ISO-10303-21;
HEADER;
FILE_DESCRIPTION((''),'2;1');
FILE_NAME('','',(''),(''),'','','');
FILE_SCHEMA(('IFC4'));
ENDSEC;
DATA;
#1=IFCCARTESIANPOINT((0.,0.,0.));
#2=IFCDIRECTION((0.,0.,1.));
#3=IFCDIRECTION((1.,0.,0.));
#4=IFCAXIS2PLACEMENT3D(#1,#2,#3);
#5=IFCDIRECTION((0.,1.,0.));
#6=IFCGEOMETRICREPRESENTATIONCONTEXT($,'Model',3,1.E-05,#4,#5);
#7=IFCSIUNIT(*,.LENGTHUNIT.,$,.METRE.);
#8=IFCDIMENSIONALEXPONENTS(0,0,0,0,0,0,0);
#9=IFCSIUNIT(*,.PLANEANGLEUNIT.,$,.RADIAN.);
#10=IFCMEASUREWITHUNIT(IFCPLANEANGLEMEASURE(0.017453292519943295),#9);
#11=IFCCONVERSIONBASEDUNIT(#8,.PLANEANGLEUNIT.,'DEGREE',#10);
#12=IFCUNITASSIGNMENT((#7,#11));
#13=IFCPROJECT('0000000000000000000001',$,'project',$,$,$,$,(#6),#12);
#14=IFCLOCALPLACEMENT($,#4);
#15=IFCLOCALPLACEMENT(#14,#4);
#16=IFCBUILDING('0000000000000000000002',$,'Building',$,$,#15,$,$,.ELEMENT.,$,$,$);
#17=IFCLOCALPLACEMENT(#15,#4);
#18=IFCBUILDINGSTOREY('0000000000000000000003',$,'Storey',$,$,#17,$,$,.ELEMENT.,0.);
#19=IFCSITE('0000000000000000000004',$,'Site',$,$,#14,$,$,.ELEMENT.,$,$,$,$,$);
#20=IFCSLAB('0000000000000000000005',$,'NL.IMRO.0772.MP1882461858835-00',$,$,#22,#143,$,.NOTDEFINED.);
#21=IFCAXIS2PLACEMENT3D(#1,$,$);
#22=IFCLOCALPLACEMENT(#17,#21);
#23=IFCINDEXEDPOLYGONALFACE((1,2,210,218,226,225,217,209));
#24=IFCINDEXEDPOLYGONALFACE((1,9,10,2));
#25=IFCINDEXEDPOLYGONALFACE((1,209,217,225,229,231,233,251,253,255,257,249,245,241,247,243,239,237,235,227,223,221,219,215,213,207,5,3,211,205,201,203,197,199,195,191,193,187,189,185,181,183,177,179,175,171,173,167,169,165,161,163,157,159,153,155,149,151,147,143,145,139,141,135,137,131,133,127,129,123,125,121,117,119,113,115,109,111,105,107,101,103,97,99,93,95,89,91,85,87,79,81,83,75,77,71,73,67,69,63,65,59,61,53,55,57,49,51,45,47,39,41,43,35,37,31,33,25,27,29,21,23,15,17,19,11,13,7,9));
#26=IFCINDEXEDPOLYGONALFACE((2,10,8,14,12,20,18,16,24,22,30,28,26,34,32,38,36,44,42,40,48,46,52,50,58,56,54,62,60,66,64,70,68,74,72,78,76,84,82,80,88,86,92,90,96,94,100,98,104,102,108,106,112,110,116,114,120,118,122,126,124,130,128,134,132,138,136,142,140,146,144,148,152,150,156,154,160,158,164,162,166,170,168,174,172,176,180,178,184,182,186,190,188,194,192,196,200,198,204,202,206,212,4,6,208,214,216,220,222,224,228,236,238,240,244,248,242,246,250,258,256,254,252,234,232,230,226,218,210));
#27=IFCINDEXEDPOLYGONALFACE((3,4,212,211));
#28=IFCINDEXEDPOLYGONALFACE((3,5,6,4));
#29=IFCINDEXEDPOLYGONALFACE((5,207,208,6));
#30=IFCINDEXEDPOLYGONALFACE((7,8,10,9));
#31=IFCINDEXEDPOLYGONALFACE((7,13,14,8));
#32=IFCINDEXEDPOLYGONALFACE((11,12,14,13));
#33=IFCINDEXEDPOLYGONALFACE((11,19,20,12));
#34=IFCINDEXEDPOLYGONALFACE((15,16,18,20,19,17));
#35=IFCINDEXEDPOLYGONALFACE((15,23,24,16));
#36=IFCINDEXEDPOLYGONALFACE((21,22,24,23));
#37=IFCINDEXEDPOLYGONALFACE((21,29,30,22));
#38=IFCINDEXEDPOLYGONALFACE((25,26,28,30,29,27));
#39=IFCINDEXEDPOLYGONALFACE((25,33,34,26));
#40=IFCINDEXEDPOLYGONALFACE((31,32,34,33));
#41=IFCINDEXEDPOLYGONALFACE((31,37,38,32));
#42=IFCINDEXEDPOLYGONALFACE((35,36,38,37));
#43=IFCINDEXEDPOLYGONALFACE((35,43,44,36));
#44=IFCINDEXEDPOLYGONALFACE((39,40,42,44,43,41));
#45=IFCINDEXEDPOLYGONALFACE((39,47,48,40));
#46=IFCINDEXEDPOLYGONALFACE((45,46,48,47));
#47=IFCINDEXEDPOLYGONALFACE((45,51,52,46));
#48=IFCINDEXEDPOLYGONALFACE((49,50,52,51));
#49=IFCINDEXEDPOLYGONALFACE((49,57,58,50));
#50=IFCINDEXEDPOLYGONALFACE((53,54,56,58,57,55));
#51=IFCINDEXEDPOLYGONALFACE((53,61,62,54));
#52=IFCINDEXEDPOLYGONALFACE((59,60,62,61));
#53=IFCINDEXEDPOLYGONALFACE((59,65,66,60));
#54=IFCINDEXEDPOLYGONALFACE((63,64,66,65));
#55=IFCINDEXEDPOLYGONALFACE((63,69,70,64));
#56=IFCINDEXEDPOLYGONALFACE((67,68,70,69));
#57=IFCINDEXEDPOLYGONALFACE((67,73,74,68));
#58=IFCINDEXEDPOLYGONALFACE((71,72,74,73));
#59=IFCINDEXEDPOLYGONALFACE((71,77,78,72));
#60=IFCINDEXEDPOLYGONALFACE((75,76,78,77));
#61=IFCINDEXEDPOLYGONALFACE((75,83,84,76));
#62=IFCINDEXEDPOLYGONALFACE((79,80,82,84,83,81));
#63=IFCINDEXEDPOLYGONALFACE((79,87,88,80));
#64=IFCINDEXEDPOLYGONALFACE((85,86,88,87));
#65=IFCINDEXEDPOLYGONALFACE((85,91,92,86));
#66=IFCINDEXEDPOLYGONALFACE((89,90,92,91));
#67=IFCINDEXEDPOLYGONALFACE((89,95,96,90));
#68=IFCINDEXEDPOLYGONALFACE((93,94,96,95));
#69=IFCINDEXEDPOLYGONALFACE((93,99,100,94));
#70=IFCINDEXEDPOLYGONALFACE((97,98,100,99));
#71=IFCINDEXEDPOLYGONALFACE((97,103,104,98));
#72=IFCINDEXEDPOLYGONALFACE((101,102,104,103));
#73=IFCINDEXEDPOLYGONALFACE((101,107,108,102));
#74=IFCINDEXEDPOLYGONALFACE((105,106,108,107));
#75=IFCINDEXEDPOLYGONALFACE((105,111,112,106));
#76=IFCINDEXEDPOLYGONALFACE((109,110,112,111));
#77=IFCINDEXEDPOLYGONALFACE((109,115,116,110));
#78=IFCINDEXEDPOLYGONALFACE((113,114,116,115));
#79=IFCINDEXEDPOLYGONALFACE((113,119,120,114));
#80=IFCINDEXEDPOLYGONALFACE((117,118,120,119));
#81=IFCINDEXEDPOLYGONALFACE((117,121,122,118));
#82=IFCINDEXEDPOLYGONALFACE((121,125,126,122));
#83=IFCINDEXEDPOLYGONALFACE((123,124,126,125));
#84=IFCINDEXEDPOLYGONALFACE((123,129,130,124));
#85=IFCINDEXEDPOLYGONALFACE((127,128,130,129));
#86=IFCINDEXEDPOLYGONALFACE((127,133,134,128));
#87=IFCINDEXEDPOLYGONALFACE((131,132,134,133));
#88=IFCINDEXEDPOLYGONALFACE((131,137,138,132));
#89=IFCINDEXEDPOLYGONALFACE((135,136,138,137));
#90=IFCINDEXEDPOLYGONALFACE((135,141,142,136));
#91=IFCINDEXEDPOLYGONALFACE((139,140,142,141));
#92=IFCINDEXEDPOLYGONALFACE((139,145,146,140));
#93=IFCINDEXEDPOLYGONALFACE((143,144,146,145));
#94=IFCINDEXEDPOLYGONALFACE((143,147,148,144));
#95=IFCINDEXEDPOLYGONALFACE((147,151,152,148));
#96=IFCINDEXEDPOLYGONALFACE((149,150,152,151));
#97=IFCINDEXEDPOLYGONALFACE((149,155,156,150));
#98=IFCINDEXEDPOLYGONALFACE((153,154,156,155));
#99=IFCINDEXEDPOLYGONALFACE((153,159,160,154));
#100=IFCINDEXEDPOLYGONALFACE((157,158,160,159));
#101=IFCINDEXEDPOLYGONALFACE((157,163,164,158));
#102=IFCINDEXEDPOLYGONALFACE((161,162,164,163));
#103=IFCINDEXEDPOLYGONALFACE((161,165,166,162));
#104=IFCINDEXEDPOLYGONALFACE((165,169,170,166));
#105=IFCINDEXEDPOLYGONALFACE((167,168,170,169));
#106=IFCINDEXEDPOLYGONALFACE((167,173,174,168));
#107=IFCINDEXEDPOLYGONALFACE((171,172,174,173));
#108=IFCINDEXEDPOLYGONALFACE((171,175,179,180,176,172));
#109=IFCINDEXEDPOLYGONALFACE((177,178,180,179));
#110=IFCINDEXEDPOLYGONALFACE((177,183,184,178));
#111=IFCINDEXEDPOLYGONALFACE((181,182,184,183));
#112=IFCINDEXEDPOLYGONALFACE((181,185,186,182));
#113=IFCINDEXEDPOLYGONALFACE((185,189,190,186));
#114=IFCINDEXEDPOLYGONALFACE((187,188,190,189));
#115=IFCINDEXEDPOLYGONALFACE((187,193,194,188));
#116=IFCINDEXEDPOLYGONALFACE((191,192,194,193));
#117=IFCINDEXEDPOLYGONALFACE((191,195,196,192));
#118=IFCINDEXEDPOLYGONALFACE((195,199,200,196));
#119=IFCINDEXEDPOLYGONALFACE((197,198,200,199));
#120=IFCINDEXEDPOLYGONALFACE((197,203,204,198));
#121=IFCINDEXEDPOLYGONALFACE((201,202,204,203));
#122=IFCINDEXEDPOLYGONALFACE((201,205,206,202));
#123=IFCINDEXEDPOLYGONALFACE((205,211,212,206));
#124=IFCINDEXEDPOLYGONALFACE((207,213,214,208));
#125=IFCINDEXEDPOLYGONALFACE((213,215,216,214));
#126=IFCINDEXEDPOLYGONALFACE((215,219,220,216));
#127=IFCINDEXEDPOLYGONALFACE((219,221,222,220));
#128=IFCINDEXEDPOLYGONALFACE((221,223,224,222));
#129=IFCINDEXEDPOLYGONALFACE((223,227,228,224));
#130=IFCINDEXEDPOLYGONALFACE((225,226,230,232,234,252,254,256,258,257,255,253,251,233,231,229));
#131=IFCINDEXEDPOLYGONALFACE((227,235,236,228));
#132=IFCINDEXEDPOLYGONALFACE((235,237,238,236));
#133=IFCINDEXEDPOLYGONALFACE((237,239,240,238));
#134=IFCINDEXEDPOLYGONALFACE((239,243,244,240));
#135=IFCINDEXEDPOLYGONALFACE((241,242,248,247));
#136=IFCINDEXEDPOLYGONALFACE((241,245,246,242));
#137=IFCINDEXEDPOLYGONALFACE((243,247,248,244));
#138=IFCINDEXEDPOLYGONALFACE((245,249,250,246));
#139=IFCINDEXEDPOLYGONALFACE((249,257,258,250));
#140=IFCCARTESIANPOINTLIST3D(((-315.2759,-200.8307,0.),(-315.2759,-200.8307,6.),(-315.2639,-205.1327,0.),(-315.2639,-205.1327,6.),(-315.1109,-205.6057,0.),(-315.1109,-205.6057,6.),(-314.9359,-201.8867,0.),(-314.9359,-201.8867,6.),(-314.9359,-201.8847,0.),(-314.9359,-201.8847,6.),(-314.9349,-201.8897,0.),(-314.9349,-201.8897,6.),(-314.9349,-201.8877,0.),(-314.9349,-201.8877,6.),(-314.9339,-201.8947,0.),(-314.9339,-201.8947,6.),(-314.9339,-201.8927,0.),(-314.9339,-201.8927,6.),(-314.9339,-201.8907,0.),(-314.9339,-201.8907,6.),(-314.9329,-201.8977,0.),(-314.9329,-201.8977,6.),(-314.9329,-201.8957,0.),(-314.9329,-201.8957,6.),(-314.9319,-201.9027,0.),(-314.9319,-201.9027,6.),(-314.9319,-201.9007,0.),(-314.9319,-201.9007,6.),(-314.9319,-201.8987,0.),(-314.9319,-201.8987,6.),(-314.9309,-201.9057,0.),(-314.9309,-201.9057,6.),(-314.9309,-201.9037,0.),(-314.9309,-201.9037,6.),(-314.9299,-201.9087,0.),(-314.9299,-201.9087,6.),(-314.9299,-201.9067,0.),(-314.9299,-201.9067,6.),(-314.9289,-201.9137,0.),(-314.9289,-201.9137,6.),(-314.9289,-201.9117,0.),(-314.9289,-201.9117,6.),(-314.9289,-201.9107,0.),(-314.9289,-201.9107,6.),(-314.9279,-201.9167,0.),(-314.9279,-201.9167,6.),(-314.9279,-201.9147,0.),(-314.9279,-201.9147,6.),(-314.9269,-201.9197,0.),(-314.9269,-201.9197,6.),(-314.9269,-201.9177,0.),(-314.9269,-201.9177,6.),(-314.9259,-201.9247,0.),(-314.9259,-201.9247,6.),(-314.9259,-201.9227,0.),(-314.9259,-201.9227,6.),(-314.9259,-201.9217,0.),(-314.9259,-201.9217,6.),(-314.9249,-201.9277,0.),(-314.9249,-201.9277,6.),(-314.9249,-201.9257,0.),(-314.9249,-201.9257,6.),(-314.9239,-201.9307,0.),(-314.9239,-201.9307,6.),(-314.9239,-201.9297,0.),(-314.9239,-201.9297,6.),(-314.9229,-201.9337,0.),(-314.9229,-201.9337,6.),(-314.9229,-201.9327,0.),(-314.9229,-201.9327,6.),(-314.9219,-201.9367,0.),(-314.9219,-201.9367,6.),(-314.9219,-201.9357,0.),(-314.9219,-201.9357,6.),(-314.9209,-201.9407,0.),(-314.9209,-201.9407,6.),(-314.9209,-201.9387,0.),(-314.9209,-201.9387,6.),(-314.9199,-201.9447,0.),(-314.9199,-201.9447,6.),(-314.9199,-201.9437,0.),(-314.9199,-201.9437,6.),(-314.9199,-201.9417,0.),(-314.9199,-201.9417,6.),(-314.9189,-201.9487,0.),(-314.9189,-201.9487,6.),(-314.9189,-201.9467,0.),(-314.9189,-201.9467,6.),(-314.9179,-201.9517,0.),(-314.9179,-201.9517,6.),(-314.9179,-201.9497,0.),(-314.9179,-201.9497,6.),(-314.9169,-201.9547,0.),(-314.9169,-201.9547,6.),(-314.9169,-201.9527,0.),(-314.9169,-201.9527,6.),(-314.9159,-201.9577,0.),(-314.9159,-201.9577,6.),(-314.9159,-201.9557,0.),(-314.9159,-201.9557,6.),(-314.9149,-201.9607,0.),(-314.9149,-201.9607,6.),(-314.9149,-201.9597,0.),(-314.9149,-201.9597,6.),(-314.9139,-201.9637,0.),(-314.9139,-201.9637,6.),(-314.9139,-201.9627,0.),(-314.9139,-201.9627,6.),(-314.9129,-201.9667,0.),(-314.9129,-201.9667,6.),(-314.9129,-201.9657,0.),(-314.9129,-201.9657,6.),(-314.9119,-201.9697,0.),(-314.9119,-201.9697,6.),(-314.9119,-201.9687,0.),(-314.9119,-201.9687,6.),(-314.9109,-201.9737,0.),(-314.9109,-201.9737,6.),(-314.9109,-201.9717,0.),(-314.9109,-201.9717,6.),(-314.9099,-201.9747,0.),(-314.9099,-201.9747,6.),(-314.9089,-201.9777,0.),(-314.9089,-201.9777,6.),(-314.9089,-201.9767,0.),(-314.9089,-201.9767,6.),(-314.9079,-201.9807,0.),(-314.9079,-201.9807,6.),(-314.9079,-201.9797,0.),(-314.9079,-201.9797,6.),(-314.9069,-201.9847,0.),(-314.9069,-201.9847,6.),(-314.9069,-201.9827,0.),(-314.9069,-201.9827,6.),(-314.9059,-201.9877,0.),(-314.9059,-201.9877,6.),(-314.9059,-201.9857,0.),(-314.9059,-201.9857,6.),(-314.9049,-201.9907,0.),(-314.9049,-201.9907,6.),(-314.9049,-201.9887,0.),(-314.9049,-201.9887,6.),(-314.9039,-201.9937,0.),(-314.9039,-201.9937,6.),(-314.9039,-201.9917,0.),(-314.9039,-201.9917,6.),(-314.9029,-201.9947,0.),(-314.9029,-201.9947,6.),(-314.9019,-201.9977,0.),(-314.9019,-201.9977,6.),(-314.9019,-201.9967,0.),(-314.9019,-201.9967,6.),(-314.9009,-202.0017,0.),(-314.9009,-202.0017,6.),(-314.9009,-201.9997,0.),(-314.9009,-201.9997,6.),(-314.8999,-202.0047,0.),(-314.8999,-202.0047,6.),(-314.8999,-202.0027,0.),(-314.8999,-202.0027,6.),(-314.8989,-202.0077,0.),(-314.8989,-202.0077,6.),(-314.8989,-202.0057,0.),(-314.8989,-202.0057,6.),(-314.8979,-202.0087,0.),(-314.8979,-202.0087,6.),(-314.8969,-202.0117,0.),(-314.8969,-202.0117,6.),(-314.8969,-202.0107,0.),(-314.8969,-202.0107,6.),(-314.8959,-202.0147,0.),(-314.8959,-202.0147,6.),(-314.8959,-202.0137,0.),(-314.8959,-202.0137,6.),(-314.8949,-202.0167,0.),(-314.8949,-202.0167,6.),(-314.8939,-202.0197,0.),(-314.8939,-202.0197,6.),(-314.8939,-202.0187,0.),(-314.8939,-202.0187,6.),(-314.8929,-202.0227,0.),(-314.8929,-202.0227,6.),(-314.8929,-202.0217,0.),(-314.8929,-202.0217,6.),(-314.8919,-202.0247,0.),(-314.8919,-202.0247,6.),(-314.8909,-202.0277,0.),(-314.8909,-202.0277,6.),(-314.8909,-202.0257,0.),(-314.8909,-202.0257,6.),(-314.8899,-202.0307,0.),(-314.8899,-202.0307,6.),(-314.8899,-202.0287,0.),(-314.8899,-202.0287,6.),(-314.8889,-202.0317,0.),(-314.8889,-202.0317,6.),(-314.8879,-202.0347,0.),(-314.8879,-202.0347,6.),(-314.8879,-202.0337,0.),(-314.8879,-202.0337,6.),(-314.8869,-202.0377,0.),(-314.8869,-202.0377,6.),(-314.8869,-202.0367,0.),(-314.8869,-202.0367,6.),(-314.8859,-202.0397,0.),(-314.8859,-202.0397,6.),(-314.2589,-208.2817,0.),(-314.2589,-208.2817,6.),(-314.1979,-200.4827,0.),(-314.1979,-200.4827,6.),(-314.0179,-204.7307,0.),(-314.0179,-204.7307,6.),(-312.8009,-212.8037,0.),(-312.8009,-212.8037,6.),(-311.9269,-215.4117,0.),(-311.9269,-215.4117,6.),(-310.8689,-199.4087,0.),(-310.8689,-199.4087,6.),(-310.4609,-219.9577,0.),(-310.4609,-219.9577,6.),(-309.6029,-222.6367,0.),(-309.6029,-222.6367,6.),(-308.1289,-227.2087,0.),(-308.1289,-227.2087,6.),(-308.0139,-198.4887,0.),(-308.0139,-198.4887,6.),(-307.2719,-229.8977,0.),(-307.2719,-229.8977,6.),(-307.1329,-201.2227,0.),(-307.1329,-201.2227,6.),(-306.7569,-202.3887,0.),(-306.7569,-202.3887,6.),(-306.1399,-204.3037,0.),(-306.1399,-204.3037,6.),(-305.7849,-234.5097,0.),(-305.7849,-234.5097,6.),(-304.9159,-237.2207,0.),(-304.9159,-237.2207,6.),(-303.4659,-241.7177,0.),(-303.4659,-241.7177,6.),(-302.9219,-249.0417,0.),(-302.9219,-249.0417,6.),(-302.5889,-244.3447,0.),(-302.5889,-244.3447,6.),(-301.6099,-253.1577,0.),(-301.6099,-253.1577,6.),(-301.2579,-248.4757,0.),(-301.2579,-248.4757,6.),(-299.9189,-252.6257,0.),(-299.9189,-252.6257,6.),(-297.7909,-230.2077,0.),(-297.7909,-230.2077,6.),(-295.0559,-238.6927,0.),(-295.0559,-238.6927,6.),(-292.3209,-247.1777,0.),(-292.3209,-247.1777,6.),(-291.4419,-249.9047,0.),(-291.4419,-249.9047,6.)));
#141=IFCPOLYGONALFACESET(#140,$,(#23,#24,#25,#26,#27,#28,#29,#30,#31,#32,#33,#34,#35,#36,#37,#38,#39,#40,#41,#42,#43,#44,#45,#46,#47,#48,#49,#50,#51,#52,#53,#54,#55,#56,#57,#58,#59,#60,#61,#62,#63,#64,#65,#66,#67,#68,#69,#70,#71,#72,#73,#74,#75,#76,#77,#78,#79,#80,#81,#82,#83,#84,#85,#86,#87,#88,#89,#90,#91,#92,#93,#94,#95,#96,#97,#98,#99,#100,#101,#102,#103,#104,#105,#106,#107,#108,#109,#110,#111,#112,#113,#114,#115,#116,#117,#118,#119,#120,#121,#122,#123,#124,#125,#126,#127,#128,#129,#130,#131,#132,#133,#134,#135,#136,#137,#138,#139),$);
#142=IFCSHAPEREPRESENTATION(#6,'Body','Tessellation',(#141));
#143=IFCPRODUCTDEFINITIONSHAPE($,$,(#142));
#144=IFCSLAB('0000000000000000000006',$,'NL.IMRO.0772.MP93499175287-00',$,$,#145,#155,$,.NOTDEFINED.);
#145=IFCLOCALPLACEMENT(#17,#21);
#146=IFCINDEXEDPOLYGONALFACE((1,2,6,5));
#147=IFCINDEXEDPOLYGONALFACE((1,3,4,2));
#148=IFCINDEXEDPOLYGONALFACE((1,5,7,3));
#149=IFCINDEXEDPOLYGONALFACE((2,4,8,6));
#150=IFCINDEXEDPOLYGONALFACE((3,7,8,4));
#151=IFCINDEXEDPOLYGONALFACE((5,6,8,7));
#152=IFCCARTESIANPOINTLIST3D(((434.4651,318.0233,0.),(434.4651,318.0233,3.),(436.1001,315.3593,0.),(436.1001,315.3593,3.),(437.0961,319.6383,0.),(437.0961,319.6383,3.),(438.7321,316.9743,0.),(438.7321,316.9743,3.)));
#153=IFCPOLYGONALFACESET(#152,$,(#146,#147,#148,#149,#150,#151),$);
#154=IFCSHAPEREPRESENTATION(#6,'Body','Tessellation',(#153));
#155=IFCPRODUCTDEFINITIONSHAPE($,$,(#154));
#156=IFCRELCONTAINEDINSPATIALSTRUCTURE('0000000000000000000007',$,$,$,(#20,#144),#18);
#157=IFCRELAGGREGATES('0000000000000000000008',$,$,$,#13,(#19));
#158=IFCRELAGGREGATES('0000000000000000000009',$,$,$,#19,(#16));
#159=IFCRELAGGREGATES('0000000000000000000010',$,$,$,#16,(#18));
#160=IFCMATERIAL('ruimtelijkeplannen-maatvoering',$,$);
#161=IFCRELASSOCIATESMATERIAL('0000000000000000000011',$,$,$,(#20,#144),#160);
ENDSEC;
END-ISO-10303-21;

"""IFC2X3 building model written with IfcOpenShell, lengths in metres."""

from ifc_helpers import new_model, entity, si_unit, converted_unit, direction, origin_with_axes, place, context, project, spatial, polyline, outline, extrude, material, element, save


model = new_model("IFC2X3")

# Units and contexts
model_context = context("Model", 3, precision=1e-05, world=origin_with_axes(), true_north=direction((0.0, 1.0, 0.0)))
ifc_project = project(units=[si_unit("LENGTHUNIT", "METRE"), converted_unit("PLANEANGLEUNIT", "DEGREE", entity("IfcPlaneAngleMeasure", 0.017453292519943295), si_unit("PLANEANGLEUNIT", "RADIAN"), dimensions=[0, 0, 0, 0, 0, 0, 0])], contexts=[model_context])

# Site, building, storey
site_placement = place(None, origin_with_axes())
site = spatial("IfcSite", under=ifc_project, at=site_placement, Name="Site", CompositionType="ELEMENT")
building_placement = place(site_placement, origin_with_axes())
building = spatial("IfcBuilding", under=site, at=building_placement, Name="Building", CompositionType="ELEMENT")
storey_placement = place(building_placement, origin_with_axes())
storey = spatial("IfcBuildingStorey", under=building, at=storey_placement, Name="Storey", CompositionType="ELEMENT", Elevation=0.0)

# Slabs
ifc_material = material(Name="ruimtelijkeplannen-maatvoering")
slab_1_placement = place(storey_placement, origin_with_axes())
element("IfcSlab", 1, at=slab_1_placement, inside=storey, material=ifc_material, Name="NL.IMRO.0772.MP1882461858835-00", PredefinedType="NOTDEFINED", context=model_context, shape_type="SweptSolid", body=[
    extrude(outline(polyline([(-315.2759, -200.8307), (-314.1979, -200.4827), (-310.8689, -199.4087), (-308.0139, -198.4887), (-307.1329, -201.2227), (-306.7569, -202.3887), (-306.1399, -204.3037), (-297.7909, -230.2077), (-295.0559, -238.6927), (-292.3209, -247.1777), (-291.4419, -249.9047), (-299.9189, -252.6257), (-301.6099, -253.1577), (-302.9219, -249.0417), (-301.2579, -248.4757), (-302.5889, -244.3447), (-303.4659, -241.7177), (-304.9159, -237.2207), (-305.7849, -234.5097), (-307.2719, -229.8977), (-308.1289, -227.2087), (-309.6029, -222.6367), (-310.4609, -219.9577), (-311.9269, -215.4117), (-312.8009, -212.8037), (-314.2589, -208.2817), (-315.1109, -205.6057), (-315.2639, -205.1327), (-314.0179, -204.7307), (-314.8859, -202.0397), (-314.8869, -202.0377), (-314.8869, -202.0367), (-314.8879, -202.0347), (-314.8879, -202.0337), (-314.8889, -202.0317), (-314.8899, -202.0307), (-314.8899, -202.0287), (-314.8909, -202.0277), (-314.8909, -202.0257), (-314.8919, -202.0247), (-314.8929, -202.0227), (-314.8929, -202.0217), (-314.8939, -202.0197), (-314.8939, -202.0187), (-314.8949, -202.0167), (-314.8959, -202.0147), (-314.8959, -202.0137), (-314.8969, -202.0117), (-314.8969, -202.0107), (-314.8979, -202.0087), (-314.8989, -202.0077), (-314.8989, -202.0057), (-314.8999, -202.0047), (-314.8999, -202.0027), (-314.9009, -202.0017), (-314.9009, -201.9997), (-314.9019, -201.9977), (-314.9019, -201.9967), (-314.9029, -201.9947), (-314.9039, -201.9937), (-314.9039, -201.9917), (-314.9049, -201.9907), (-314.9049, -201.9887), (-314.9059, -201.9877), (-314.9059, -201.9857), (-314.9069, -201.9847), (-314.9069, -201.9827), (-314.9079, -201.9807), (-314.9079, -201.9797), (-314.9089, -201.9777), (-314.9089, -201.9767), (-314.9099, -201.9747), (-314.9109, -201.9737), (-314.9109, -201.9717), (-314.9119, -201.9697), (-314.9119, -201.9687), (-314.9129, -201.9667), (-314.9129, -201.9657), (-314.9139, -201.9637), (-314.9139, -201.9627), (-314.9149, -201.9607), (-314.9149, -201.9597), (-314.9159, -201.9577), (-314.9159, -201.9557), (-314.9169, -201.9547), (-314.9169, -201.9527), (-314.9179, -201.9517), (-314.9179, -201.9497), (-314.9189, -201.9487), (-314.9189, -201.9467), (-314.9199, -201.9447), (-314.9199, -201.9437), (-314.9199, -201.9417), (-314.9209, -201.9407), (-314.9209, -201.9387), (-314.9219, -201.9367), (-314.9219, -201.9357), (-314.9229, -201.9337), (-314.9229, -201.9327), (-314.9239, -201.9307), (-314.9239, -201.9297), (-314.9249, -201.9277), (-314.9249, -201.9257), (-314.9259, -201.9247), (-314.9259, -201.9227), (-314.9259, -201.9217), (-314.9269, -201.9197), (-314.9269, -201.9177), (-314.9279, -201.9167), (-314.9279, -201.9147), (-314.9289, -201.9137), (-314.9289, -201.9117), (-314.9289, -201.9107), (-314.9299, -201.9087), (-314.9299, -201.9067), (-314.9309, -201.9057), (-314.9309, -201.9037), (-314.9319, -201.9027), (-314.9319, -201.9007), (-314.9319, -201.8987), (-314.9329, -201.8977), (-314.9329, -201.8957), (-314.9339, -201.8947), (-314.9339, -201.8927), (-314.9339, -201.8907), (-314.9349, -201.8897), (-314.9349, -201.8877), (-314.9359, -201.8867), (-314.9359, -201.8847), (-315.2759, -200.8307)])), origin_with_axes(), (0.0, 0.0, 1.0), 6.0),
])
slab_2_placement = place(storey_placement, origin_with_axes())
element("IfcSlab", 2, at=slab_2_placement, inside=storey, material=ifc_material, Name="NL.IMRO.0772.MP93499175287-00", PredefinedType="NOTDEFINED", context=model_context, shape_type="SweptSolid", body=[
    extrude(outline(polyline([(438.7321, 316.9743), (436.1001, 315.3593), (434.4651, 318.0233), (437.0961, 319.6383), (438.7321, 316.9743)])), origin_with_axes(), (0.0, 0.0, 1.0), 3.0),
])

save(model, "model.ifc")
